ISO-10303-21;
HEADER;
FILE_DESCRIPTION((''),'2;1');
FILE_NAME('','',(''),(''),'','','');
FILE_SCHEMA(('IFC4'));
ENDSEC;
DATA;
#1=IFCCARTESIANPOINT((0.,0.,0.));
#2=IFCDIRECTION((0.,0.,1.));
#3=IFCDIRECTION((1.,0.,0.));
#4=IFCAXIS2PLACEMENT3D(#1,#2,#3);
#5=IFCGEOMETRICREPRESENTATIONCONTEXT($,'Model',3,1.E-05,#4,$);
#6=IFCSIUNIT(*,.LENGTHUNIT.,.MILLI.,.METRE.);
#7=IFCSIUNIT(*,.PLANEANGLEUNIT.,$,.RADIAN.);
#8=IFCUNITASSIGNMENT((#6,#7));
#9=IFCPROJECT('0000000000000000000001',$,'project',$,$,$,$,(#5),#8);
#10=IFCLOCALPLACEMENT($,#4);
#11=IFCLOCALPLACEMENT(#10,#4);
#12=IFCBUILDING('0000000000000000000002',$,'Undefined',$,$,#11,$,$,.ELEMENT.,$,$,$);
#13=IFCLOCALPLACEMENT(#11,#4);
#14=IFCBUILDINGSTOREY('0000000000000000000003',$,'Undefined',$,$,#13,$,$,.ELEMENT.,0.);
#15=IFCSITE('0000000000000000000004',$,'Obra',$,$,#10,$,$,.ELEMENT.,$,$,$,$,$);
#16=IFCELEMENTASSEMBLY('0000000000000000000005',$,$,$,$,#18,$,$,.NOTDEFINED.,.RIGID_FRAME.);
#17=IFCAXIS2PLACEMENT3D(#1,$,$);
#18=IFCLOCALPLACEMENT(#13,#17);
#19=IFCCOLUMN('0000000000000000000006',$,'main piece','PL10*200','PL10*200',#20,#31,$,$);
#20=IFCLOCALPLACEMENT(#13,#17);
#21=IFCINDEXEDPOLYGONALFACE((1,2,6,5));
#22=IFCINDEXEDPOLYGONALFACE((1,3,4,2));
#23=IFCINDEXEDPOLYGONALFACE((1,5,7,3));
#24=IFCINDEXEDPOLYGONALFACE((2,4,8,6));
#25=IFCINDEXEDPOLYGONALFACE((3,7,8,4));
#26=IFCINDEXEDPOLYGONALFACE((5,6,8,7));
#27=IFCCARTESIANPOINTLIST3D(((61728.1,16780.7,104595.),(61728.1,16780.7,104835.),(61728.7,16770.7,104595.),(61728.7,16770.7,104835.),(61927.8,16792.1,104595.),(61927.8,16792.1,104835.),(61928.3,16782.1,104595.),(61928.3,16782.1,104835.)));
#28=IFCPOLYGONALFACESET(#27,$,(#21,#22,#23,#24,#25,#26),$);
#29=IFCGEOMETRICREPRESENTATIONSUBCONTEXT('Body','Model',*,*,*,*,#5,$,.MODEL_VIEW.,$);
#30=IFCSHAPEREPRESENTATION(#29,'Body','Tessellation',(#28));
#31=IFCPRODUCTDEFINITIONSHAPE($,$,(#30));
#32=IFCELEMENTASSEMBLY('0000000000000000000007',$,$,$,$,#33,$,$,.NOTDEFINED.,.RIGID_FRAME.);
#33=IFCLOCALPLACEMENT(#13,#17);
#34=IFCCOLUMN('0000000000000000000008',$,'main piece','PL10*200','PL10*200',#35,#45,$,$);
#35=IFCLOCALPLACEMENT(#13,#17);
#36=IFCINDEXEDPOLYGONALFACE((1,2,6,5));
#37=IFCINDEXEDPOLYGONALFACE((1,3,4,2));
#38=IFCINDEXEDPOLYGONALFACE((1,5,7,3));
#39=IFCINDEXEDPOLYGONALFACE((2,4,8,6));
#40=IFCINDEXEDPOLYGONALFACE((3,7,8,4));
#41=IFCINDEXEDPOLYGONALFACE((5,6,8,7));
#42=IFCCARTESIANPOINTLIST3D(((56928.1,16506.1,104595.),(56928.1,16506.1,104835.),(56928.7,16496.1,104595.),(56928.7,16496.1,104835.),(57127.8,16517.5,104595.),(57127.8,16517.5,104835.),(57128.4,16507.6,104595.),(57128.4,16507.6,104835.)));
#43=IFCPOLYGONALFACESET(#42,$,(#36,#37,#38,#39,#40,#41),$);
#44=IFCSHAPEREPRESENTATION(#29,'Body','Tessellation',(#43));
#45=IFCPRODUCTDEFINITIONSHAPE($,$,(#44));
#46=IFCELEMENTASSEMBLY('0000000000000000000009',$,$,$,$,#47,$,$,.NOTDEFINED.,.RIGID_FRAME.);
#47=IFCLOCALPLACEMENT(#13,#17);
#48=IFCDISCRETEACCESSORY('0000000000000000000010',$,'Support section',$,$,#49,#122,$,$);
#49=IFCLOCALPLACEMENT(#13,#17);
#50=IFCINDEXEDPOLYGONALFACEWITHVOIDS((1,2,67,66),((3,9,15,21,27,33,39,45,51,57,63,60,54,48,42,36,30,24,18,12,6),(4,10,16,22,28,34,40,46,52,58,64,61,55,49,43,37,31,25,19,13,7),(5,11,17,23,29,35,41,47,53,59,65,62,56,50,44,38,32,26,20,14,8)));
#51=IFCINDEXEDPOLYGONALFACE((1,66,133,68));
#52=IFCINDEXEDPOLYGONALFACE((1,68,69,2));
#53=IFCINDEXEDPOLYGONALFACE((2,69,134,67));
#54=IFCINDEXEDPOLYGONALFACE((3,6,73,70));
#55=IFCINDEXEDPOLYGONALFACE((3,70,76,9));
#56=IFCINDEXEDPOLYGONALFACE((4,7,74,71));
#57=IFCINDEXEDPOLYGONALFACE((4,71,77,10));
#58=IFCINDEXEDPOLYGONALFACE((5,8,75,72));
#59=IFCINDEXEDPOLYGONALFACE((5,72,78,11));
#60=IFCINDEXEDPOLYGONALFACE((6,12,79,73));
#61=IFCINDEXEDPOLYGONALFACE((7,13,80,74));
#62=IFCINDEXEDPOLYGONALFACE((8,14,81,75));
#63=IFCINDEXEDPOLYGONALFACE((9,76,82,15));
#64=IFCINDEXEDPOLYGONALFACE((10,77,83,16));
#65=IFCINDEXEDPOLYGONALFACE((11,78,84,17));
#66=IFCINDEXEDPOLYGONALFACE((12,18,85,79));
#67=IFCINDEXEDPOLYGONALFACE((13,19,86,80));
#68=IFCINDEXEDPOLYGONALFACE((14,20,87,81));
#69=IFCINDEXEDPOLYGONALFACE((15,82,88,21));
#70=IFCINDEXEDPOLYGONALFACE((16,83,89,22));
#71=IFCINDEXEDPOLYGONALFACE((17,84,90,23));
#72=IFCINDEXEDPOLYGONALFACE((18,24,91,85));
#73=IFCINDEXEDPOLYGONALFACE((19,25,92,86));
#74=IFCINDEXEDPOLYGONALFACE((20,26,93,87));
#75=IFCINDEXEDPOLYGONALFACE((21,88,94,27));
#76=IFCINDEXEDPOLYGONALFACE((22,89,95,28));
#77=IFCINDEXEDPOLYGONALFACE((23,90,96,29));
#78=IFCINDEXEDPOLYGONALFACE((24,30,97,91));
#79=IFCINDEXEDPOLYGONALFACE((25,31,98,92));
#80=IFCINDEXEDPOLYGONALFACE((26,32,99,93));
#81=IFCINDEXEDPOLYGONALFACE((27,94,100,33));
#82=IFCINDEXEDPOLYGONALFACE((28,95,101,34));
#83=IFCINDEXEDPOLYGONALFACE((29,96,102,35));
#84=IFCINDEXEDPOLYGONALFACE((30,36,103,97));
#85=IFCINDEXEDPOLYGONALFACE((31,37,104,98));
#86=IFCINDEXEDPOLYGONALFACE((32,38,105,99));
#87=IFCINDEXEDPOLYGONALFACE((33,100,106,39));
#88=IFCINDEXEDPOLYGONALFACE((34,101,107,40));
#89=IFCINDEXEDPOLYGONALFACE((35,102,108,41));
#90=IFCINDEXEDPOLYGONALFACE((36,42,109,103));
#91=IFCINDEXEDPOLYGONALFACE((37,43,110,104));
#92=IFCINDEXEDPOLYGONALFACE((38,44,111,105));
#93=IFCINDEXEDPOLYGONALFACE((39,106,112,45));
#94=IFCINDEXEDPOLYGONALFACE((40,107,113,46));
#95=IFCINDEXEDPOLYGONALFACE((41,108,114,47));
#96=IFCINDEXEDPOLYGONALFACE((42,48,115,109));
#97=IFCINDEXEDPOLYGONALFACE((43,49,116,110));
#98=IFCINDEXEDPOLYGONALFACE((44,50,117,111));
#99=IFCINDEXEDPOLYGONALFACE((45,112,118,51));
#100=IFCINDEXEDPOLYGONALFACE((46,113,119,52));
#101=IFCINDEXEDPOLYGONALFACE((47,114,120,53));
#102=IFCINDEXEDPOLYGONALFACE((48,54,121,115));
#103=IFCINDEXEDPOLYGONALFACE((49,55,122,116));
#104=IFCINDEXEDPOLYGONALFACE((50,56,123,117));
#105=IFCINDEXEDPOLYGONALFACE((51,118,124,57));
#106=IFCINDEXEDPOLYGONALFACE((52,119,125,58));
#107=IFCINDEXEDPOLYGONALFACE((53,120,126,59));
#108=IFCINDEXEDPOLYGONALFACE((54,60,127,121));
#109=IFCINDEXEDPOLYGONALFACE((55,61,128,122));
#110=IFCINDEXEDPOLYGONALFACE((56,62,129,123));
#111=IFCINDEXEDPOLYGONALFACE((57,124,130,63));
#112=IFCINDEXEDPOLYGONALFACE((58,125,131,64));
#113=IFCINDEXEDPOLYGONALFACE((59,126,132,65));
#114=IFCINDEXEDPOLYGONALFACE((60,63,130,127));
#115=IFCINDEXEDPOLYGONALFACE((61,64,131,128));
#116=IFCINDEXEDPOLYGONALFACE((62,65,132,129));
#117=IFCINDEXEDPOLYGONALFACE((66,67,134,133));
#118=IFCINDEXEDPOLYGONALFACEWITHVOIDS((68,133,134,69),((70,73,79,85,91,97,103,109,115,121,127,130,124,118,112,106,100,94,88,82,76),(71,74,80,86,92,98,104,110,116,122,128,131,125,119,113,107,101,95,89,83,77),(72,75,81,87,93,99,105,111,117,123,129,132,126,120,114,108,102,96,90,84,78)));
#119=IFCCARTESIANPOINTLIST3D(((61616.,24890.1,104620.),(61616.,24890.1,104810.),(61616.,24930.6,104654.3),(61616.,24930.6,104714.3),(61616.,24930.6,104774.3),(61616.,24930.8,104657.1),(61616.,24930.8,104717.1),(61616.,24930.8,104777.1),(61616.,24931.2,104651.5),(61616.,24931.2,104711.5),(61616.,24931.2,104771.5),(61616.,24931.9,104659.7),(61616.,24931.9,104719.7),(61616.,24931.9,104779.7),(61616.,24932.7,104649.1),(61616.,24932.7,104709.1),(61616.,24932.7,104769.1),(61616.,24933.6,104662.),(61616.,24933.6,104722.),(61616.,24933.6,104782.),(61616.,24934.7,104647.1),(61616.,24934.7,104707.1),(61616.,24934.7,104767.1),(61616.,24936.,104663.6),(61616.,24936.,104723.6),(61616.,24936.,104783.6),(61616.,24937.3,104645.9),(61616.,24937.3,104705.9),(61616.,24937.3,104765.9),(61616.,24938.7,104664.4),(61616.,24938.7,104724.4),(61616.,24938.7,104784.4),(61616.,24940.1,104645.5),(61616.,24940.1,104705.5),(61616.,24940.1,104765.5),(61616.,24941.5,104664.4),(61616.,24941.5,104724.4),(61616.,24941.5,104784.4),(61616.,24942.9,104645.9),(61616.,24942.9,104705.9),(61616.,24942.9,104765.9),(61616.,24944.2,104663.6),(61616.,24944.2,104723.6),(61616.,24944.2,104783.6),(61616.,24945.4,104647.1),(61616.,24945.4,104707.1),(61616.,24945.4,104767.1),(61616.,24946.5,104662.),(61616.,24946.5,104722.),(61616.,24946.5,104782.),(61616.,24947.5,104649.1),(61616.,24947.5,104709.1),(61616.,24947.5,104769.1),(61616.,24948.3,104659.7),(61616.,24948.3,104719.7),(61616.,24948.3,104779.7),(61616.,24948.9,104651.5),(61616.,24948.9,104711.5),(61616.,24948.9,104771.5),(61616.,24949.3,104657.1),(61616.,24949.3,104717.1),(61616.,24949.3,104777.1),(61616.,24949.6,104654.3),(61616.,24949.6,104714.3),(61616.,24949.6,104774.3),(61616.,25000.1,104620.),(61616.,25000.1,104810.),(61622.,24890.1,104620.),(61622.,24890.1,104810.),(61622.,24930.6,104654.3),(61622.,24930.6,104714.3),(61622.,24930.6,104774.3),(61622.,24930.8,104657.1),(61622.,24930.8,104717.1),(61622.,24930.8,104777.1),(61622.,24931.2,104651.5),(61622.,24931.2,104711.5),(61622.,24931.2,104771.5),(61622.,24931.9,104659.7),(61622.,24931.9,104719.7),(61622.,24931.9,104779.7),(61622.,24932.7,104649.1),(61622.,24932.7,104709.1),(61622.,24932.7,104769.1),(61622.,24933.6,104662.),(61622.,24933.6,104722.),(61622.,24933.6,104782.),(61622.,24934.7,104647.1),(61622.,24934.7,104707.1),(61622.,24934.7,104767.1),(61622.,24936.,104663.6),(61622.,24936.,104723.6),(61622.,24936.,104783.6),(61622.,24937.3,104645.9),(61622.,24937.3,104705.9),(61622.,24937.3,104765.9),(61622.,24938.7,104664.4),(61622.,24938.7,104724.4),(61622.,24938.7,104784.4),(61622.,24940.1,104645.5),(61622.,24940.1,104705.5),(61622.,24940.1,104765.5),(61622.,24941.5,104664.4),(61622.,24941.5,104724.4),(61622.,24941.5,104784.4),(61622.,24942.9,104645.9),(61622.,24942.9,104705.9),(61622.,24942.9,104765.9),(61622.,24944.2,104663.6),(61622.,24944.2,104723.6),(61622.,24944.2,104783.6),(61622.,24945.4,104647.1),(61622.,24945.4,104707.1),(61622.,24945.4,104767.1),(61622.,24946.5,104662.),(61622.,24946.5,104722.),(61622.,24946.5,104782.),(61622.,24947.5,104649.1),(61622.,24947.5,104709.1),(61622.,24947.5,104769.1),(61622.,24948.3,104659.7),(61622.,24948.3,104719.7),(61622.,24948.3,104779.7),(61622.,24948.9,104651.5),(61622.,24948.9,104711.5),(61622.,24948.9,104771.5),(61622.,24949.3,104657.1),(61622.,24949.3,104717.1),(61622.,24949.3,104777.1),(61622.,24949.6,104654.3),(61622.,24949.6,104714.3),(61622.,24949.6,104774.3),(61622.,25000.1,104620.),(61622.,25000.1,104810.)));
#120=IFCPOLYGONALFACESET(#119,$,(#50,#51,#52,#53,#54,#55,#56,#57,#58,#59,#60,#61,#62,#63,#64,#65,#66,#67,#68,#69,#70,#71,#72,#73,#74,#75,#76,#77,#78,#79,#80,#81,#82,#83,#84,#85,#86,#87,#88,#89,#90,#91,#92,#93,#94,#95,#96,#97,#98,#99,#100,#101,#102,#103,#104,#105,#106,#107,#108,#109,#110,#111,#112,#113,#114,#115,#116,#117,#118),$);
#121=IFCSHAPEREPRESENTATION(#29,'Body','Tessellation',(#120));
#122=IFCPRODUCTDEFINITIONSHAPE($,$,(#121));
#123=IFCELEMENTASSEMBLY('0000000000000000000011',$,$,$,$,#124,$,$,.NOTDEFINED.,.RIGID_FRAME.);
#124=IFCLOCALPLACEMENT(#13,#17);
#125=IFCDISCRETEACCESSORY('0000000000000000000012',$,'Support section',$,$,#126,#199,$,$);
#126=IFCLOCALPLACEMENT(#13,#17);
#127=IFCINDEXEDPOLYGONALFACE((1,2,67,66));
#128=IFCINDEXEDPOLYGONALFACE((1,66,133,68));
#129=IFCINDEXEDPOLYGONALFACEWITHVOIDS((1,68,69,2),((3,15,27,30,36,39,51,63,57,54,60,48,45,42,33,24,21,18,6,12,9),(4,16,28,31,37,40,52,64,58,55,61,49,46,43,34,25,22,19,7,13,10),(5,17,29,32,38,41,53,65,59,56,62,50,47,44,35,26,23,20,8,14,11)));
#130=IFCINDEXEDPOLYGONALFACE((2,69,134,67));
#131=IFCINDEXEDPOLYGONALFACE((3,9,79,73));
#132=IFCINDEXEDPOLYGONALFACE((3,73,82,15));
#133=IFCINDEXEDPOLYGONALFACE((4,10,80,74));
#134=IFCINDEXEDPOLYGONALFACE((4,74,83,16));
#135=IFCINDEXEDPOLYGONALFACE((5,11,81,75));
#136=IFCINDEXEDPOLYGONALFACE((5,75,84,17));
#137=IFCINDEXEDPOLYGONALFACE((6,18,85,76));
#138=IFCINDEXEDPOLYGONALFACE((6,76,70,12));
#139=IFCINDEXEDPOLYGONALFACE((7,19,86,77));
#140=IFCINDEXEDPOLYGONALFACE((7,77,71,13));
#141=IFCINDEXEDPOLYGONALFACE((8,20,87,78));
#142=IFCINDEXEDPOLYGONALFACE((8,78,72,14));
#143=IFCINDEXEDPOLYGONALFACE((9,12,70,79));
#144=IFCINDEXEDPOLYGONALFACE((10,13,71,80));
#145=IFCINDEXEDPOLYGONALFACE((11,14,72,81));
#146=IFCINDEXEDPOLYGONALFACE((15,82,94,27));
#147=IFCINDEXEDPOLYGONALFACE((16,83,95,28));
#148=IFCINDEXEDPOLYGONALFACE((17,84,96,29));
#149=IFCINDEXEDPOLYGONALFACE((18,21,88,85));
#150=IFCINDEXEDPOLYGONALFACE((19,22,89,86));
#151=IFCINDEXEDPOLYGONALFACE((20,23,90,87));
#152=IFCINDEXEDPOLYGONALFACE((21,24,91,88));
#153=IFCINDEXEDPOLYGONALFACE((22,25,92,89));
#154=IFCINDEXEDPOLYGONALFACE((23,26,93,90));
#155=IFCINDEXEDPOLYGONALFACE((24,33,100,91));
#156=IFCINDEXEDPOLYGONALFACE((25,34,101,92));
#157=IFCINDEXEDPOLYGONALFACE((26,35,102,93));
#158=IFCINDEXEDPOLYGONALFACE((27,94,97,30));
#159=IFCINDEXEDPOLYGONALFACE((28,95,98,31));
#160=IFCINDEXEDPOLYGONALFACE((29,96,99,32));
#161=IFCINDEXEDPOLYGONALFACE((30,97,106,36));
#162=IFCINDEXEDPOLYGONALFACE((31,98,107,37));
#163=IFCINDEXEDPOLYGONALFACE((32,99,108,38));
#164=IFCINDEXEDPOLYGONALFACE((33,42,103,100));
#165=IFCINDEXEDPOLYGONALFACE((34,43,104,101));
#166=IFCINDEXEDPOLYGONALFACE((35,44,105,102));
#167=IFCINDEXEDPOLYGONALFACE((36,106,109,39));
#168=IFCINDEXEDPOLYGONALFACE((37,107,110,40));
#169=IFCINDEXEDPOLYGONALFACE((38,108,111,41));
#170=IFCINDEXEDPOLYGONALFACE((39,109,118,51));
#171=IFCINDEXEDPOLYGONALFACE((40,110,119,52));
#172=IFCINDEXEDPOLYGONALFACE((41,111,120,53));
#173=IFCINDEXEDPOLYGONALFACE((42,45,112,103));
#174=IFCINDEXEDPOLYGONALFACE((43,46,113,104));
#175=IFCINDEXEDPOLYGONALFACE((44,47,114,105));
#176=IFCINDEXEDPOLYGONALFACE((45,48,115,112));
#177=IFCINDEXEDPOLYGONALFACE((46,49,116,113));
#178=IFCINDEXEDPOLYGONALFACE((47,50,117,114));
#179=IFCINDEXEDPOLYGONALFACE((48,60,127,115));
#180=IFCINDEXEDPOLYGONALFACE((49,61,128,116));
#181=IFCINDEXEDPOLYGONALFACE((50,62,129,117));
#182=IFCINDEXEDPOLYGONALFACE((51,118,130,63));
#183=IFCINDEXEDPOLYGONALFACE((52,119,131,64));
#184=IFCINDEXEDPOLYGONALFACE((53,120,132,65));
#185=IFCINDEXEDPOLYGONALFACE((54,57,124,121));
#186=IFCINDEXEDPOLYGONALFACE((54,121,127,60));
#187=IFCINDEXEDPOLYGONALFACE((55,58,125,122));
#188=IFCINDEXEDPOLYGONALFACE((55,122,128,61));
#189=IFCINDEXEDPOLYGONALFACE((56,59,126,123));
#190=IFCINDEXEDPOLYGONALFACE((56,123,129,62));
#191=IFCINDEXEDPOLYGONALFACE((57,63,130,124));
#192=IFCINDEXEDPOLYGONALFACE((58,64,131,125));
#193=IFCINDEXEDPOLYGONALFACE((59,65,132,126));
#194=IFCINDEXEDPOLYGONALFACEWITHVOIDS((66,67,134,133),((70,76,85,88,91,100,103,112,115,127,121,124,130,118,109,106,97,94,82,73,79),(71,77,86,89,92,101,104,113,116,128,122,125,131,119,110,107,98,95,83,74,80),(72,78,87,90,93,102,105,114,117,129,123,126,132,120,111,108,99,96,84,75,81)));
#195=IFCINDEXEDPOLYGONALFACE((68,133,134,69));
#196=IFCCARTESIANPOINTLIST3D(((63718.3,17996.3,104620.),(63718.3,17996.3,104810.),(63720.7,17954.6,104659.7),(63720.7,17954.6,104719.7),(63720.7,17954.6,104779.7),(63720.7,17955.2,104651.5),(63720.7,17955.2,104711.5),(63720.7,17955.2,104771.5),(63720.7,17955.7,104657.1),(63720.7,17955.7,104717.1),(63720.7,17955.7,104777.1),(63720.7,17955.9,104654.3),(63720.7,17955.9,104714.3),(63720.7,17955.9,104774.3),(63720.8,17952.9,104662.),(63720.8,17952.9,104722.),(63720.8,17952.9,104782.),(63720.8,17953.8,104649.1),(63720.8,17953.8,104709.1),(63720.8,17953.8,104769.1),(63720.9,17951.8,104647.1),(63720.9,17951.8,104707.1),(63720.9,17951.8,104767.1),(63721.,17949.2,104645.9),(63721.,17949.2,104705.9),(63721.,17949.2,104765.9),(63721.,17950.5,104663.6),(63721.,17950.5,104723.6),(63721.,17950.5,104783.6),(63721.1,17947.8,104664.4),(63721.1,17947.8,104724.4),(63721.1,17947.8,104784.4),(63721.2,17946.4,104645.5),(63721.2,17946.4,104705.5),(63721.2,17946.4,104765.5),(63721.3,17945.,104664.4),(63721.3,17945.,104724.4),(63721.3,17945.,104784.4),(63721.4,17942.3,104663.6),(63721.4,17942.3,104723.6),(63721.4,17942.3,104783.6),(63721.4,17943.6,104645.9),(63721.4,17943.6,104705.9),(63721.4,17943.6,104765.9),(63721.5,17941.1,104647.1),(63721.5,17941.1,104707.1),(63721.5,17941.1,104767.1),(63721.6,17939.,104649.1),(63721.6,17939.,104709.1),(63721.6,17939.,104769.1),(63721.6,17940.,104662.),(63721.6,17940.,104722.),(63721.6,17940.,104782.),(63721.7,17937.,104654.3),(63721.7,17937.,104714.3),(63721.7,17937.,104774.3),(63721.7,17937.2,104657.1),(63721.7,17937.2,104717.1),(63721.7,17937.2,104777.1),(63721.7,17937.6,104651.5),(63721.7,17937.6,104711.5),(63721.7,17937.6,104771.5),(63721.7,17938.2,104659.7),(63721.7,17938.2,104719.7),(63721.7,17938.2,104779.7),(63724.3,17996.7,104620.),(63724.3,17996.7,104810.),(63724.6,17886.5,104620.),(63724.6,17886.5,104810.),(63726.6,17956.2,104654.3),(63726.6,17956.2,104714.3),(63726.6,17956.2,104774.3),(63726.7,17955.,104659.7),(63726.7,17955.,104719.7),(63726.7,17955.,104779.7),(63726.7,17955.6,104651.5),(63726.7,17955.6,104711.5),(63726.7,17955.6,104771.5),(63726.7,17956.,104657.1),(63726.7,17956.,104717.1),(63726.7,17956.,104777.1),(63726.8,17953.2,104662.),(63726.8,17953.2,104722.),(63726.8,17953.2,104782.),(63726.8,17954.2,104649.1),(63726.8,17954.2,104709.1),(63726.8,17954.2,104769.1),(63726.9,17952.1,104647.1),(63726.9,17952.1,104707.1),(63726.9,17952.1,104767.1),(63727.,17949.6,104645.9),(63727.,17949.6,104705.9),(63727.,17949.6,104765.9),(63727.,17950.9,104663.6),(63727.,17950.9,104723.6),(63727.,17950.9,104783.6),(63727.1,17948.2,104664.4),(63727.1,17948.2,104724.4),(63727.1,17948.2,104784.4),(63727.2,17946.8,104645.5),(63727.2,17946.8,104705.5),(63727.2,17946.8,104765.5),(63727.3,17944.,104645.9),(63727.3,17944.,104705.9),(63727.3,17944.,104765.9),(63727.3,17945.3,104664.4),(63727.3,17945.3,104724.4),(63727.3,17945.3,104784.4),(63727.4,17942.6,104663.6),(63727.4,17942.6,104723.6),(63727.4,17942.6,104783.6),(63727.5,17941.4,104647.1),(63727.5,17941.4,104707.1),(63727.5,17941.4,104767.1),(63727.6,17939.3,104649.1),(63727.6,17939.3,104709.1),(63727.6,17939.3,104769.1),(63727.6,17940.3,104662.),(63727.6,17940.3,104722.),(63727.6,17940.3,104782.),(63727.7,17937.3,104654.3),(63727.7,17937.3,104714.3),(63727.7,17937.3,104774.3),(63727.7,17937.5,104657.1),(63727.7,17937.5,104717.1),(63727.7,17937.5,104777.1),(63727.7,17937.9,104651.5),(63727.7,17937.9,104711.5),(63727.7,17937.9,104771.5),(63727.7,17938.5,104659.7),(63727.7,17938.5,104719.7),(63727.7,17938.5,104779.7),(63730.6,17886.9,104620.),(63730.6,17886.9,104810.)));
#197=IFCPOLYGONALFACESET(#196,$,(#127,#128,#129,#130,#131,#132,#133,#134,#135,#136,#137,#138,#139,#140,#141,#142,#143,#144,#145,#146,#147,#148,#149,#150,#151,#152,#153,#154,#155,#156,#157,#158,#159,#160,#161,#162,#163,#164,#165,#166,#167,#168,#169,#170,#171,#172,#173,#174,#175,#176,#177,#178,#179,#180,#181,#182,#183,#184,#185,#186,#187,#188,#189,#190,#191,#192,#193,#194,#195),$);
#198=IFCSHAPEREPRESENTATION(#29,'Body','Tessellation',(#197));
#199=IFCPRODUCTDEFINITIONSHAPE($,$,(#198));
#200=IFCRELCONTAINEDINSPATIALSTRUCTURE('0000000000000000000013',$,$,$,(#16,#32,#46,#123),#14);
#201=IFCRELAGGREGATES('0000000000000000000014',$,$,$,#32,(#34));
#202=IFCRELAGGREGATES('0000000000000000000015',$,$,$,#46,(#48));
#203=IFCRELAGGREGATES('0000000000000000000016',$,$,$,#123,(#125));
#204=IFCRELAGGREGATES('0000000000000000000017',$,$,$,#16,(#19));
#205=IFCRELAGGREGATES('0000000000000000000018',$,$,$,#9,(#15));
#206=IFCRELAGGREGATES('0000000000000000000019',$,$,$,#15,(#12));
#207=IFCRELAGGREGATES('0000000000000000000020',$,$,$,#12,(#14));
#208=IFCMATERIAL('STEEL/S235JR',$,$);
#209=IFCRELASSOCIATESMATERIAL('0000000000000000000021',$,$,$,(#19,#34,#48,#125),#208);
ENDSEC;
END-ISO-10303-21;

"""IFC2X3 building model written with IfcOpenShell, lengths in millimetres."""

from ifc_helpers import new_model, si_unit, frame, origin_with_axes, origin_2d_with_axis, place, context, subcontext, project, spatial, rectangle, circle, extrude, source, transform, mapped, material, element, aggregate, save


model = new_model("IFC2X3")

# Units and contexts
model_context = context("Model", 3, precision=1e-05, world=origin_with_axes())
body_context = subcontext(model_context, "Body", "Model", "MODEL_VIEW")
ifc_project = project(units=[si_unit("LENGTHUNIT", "METRE", prefix="MILLI"), si_unit("PLANEANGLEUNIT", "RADIAN")], contexts=[model_context])

# Site, building, storey
site_placement = place(None, origin_with_axes())
site = spatial("IfcSite", under=ifc_project, at=site_placement, Name="Obra", CompositionType="ELEMENT")
building_placement = place(site_placement, origin_with_axes())
building = spatial("IfcBuilding", under=site, at=building_placement, Name="Undefined", CompositionType="ELEMENT")
storey_placement = place(building_placement, origin_with_axes())
storey = spatial("IfcBuildingStorey", under=building, at=storey_placement, Name="Undefined", CompositionType="ELEMENT", Elevation=0.0)

# Element assemblies, columns
assembly_1_placement = place(storey_placement, origin_with_axes())
assembly_1 = element("IfcElementAssembly", 1, at=assembly_1_placement, inside=storey, AssemblyPlace="NOTDEFINED", PredefinedType="RIGID_FRAME")
ifc_material = material(Name="STEEL/S235JR")
column_1_placement = place(assembly_1_placement, frame((61828.2, 16781.4, 104595.0), z_axis=(0.0, 0.0, 1.0), x_axis=(-0.998368, -0.057107, 0.0)))
column_1 = element("IfcColumn", 2, at=column_1_placement, material=ifc_material, Name="main piece", Description="PL10*200", ObjectType="PL10*200", context=body_context, shape_type="SweptSolid", body=[
    extrude(rectangle(XDim=10.0, YDim=200.0, at=origin_2d_with_axis()), frame((0.0, 0.0, 240.0), z_axis=(0.0, 0.0, -1.0), x_axis=(0.0, 1.0, 0.0)), (0.0, 0.0, 1.0), 240.0),
])
assembly_2_placement = place(storey_placement, origin_with_axes())
assembly_2 = element("IfcElementAssembly", 3, at=assembly_2_placement, inside=storey, AssemblyPlace="NOTDEFINED", PredefinedType="RIGID_FRAME")
column_2_placement = place(assembly_2_placement, frame((57028.3, 16506.8, 104595.0), z_axis=(0.0, 0.0, 1.0), x_axis=(-0.998368, -0.057107, 0.0)))
column_2 = element("IfcColumn", 4, at=column_2_placement, material=ifc_material, Name="main piece", Description="PL10*200", ObjectType="PL10*200", context=body_context, shape_type="SweptSolid", body=[
    extrude(rectangle(XDim=10.0, YDim=200.0, at=origin_2d_with_axis()), frame((0.0, 0.0, 240.0), z_axis=(0.0, 0.0, -1.0), x_axis=(0.0, 1.0, 0.0)), (0.0, 0.0, 1.0), 240.0),
])
aggregate(assembly_2, [column_2])

# Element assemblies, discrete accessories, openings
assembly_3_placement = place(storey_placement, origin_with_axes())
assembly_3 = element("IfcElementAssembly", 5, at=assembly_3_placement, inside=storey, AssemblyPlace="NOTDEFINED", PredefinedType="RIGID_FRAME")
discrete_accessory_1_placement = place(assembly_3_placement, frame((61619.0, 24945.1, 104620.0), z_axis=(0.0, 0.0, 1.0), x_axis=(-0.000002, 1.0, 0.0)))
discrete_accessory_1 = element("IfcDiscreteAccessory", 6, at=discrete_accessory_1_placement, material=ifc_material, Name="Support section", context=body_context, shape_type="SweptSolid", body=[
    extrude(rectangle(XDim=6.0, YDim=110.0, at=origin_2d_with_axis()), frame((0.0, 0.0, 190.0), z_axis=(0.0, 0.0, -1.0), x_axis=(0.0, 1.0, 0.0)), (0.0, 0.0, 1.0), 190.0),
])
shared_shape_1 = source(origin_with_axes(), body_context, "Body", "SweptSolid", [
    extrude(circle(Radius=9.5, at=origin_2d_with_axis()), frame((0.0, -9.2, 0.0), z_axis=(0.0, 1.0, 0.0), x_axis=(1.0, 0.0, 0.0)), (0.0, 0.0, 1.0), 6.2),
])
opening_1_placement = place(assembly_3_placement, frame((61625.1, 24990.1, 104835.0), z_axis=(0.000002, -1.0, 0.0), x_axis=(0.0, 0.0, -1.0)))
element("IfcOpeningElement", 7, at=opening_1_placement, cuts=discrete_accessory_1, ObjectType="Opening", context=body_context, shape_type="MappedRepresentation", body=[
    mapped(shared_shape_1, transform((60.0, 0.0, 50.0))),
    mapped(shared_shape_1, transform((120.0, 0.0, 50.0))),
    mapped(shared_shape_1, transform((180.0, 0.0, 50.0))),
])
aggregate(assembly_3, [discrete_accessory_1])
assembly_4_placement = place(storey_placement, origin_with_axes())
assembly_4 = element("IfcElementAssembly", 8, at=assembly_4_placement, inside=storey, AssemblyPlace="NOTDEFINED", PredefinedType="RIGID_FRAME")
discrete_accessory_2_placement = place(assembly_4_placement, frame((63724.5, 17941.6, 104620.0), z_axis=(0.0, 0.0, 1.0), x_axis=(0.057107, -0.998368, 0.0)))
discrete_accessory_2 = element("IfcDiscreteAccessory", 9, at=discrete_accessory_2_placement, material=ifc_material, Name="Support section", context=body_context, shape_type="SweptSolid", body=[
    extrude(rectangle(XDim=6.0, YDim=110.0, at=origin_2d_with_axis()), frame((0.0, 0.0, 190.0), z_axis=(0.0, 0.0, -1.0), x_axis=(0.0, 1.0, 0.0)), (0.0, 0.0, 1.0), 190.0),
])
opening_2_placement = place(assembly_4_placement, frame((63721.0, 17896.3, 104835.0), z_axis=(-0.057107, 0.998368, 0.0), x_axis=(0.0, 0.0, -1.0)))
element("IfcOpeningElement", 10, at=opening_2_placement, cuts=discrete_accessory_2, ObjectType="Opening", context=body_context, shape_type="MappedRepresentation", body=[
    mapped(shared_shape_1, transform((60.0, 0.0, 50.0))),
    mapped(shared_shape_1, transform((120.0, 0.0, 50.0))),
    mapped(shared_shape_1, transform((180.0, 0.0, 50.0))),
])
aggregate(assembly_4, [discrete_accessory_2])

aggregate(assembly_1, [column_1])

save(model, "model.ifc")
